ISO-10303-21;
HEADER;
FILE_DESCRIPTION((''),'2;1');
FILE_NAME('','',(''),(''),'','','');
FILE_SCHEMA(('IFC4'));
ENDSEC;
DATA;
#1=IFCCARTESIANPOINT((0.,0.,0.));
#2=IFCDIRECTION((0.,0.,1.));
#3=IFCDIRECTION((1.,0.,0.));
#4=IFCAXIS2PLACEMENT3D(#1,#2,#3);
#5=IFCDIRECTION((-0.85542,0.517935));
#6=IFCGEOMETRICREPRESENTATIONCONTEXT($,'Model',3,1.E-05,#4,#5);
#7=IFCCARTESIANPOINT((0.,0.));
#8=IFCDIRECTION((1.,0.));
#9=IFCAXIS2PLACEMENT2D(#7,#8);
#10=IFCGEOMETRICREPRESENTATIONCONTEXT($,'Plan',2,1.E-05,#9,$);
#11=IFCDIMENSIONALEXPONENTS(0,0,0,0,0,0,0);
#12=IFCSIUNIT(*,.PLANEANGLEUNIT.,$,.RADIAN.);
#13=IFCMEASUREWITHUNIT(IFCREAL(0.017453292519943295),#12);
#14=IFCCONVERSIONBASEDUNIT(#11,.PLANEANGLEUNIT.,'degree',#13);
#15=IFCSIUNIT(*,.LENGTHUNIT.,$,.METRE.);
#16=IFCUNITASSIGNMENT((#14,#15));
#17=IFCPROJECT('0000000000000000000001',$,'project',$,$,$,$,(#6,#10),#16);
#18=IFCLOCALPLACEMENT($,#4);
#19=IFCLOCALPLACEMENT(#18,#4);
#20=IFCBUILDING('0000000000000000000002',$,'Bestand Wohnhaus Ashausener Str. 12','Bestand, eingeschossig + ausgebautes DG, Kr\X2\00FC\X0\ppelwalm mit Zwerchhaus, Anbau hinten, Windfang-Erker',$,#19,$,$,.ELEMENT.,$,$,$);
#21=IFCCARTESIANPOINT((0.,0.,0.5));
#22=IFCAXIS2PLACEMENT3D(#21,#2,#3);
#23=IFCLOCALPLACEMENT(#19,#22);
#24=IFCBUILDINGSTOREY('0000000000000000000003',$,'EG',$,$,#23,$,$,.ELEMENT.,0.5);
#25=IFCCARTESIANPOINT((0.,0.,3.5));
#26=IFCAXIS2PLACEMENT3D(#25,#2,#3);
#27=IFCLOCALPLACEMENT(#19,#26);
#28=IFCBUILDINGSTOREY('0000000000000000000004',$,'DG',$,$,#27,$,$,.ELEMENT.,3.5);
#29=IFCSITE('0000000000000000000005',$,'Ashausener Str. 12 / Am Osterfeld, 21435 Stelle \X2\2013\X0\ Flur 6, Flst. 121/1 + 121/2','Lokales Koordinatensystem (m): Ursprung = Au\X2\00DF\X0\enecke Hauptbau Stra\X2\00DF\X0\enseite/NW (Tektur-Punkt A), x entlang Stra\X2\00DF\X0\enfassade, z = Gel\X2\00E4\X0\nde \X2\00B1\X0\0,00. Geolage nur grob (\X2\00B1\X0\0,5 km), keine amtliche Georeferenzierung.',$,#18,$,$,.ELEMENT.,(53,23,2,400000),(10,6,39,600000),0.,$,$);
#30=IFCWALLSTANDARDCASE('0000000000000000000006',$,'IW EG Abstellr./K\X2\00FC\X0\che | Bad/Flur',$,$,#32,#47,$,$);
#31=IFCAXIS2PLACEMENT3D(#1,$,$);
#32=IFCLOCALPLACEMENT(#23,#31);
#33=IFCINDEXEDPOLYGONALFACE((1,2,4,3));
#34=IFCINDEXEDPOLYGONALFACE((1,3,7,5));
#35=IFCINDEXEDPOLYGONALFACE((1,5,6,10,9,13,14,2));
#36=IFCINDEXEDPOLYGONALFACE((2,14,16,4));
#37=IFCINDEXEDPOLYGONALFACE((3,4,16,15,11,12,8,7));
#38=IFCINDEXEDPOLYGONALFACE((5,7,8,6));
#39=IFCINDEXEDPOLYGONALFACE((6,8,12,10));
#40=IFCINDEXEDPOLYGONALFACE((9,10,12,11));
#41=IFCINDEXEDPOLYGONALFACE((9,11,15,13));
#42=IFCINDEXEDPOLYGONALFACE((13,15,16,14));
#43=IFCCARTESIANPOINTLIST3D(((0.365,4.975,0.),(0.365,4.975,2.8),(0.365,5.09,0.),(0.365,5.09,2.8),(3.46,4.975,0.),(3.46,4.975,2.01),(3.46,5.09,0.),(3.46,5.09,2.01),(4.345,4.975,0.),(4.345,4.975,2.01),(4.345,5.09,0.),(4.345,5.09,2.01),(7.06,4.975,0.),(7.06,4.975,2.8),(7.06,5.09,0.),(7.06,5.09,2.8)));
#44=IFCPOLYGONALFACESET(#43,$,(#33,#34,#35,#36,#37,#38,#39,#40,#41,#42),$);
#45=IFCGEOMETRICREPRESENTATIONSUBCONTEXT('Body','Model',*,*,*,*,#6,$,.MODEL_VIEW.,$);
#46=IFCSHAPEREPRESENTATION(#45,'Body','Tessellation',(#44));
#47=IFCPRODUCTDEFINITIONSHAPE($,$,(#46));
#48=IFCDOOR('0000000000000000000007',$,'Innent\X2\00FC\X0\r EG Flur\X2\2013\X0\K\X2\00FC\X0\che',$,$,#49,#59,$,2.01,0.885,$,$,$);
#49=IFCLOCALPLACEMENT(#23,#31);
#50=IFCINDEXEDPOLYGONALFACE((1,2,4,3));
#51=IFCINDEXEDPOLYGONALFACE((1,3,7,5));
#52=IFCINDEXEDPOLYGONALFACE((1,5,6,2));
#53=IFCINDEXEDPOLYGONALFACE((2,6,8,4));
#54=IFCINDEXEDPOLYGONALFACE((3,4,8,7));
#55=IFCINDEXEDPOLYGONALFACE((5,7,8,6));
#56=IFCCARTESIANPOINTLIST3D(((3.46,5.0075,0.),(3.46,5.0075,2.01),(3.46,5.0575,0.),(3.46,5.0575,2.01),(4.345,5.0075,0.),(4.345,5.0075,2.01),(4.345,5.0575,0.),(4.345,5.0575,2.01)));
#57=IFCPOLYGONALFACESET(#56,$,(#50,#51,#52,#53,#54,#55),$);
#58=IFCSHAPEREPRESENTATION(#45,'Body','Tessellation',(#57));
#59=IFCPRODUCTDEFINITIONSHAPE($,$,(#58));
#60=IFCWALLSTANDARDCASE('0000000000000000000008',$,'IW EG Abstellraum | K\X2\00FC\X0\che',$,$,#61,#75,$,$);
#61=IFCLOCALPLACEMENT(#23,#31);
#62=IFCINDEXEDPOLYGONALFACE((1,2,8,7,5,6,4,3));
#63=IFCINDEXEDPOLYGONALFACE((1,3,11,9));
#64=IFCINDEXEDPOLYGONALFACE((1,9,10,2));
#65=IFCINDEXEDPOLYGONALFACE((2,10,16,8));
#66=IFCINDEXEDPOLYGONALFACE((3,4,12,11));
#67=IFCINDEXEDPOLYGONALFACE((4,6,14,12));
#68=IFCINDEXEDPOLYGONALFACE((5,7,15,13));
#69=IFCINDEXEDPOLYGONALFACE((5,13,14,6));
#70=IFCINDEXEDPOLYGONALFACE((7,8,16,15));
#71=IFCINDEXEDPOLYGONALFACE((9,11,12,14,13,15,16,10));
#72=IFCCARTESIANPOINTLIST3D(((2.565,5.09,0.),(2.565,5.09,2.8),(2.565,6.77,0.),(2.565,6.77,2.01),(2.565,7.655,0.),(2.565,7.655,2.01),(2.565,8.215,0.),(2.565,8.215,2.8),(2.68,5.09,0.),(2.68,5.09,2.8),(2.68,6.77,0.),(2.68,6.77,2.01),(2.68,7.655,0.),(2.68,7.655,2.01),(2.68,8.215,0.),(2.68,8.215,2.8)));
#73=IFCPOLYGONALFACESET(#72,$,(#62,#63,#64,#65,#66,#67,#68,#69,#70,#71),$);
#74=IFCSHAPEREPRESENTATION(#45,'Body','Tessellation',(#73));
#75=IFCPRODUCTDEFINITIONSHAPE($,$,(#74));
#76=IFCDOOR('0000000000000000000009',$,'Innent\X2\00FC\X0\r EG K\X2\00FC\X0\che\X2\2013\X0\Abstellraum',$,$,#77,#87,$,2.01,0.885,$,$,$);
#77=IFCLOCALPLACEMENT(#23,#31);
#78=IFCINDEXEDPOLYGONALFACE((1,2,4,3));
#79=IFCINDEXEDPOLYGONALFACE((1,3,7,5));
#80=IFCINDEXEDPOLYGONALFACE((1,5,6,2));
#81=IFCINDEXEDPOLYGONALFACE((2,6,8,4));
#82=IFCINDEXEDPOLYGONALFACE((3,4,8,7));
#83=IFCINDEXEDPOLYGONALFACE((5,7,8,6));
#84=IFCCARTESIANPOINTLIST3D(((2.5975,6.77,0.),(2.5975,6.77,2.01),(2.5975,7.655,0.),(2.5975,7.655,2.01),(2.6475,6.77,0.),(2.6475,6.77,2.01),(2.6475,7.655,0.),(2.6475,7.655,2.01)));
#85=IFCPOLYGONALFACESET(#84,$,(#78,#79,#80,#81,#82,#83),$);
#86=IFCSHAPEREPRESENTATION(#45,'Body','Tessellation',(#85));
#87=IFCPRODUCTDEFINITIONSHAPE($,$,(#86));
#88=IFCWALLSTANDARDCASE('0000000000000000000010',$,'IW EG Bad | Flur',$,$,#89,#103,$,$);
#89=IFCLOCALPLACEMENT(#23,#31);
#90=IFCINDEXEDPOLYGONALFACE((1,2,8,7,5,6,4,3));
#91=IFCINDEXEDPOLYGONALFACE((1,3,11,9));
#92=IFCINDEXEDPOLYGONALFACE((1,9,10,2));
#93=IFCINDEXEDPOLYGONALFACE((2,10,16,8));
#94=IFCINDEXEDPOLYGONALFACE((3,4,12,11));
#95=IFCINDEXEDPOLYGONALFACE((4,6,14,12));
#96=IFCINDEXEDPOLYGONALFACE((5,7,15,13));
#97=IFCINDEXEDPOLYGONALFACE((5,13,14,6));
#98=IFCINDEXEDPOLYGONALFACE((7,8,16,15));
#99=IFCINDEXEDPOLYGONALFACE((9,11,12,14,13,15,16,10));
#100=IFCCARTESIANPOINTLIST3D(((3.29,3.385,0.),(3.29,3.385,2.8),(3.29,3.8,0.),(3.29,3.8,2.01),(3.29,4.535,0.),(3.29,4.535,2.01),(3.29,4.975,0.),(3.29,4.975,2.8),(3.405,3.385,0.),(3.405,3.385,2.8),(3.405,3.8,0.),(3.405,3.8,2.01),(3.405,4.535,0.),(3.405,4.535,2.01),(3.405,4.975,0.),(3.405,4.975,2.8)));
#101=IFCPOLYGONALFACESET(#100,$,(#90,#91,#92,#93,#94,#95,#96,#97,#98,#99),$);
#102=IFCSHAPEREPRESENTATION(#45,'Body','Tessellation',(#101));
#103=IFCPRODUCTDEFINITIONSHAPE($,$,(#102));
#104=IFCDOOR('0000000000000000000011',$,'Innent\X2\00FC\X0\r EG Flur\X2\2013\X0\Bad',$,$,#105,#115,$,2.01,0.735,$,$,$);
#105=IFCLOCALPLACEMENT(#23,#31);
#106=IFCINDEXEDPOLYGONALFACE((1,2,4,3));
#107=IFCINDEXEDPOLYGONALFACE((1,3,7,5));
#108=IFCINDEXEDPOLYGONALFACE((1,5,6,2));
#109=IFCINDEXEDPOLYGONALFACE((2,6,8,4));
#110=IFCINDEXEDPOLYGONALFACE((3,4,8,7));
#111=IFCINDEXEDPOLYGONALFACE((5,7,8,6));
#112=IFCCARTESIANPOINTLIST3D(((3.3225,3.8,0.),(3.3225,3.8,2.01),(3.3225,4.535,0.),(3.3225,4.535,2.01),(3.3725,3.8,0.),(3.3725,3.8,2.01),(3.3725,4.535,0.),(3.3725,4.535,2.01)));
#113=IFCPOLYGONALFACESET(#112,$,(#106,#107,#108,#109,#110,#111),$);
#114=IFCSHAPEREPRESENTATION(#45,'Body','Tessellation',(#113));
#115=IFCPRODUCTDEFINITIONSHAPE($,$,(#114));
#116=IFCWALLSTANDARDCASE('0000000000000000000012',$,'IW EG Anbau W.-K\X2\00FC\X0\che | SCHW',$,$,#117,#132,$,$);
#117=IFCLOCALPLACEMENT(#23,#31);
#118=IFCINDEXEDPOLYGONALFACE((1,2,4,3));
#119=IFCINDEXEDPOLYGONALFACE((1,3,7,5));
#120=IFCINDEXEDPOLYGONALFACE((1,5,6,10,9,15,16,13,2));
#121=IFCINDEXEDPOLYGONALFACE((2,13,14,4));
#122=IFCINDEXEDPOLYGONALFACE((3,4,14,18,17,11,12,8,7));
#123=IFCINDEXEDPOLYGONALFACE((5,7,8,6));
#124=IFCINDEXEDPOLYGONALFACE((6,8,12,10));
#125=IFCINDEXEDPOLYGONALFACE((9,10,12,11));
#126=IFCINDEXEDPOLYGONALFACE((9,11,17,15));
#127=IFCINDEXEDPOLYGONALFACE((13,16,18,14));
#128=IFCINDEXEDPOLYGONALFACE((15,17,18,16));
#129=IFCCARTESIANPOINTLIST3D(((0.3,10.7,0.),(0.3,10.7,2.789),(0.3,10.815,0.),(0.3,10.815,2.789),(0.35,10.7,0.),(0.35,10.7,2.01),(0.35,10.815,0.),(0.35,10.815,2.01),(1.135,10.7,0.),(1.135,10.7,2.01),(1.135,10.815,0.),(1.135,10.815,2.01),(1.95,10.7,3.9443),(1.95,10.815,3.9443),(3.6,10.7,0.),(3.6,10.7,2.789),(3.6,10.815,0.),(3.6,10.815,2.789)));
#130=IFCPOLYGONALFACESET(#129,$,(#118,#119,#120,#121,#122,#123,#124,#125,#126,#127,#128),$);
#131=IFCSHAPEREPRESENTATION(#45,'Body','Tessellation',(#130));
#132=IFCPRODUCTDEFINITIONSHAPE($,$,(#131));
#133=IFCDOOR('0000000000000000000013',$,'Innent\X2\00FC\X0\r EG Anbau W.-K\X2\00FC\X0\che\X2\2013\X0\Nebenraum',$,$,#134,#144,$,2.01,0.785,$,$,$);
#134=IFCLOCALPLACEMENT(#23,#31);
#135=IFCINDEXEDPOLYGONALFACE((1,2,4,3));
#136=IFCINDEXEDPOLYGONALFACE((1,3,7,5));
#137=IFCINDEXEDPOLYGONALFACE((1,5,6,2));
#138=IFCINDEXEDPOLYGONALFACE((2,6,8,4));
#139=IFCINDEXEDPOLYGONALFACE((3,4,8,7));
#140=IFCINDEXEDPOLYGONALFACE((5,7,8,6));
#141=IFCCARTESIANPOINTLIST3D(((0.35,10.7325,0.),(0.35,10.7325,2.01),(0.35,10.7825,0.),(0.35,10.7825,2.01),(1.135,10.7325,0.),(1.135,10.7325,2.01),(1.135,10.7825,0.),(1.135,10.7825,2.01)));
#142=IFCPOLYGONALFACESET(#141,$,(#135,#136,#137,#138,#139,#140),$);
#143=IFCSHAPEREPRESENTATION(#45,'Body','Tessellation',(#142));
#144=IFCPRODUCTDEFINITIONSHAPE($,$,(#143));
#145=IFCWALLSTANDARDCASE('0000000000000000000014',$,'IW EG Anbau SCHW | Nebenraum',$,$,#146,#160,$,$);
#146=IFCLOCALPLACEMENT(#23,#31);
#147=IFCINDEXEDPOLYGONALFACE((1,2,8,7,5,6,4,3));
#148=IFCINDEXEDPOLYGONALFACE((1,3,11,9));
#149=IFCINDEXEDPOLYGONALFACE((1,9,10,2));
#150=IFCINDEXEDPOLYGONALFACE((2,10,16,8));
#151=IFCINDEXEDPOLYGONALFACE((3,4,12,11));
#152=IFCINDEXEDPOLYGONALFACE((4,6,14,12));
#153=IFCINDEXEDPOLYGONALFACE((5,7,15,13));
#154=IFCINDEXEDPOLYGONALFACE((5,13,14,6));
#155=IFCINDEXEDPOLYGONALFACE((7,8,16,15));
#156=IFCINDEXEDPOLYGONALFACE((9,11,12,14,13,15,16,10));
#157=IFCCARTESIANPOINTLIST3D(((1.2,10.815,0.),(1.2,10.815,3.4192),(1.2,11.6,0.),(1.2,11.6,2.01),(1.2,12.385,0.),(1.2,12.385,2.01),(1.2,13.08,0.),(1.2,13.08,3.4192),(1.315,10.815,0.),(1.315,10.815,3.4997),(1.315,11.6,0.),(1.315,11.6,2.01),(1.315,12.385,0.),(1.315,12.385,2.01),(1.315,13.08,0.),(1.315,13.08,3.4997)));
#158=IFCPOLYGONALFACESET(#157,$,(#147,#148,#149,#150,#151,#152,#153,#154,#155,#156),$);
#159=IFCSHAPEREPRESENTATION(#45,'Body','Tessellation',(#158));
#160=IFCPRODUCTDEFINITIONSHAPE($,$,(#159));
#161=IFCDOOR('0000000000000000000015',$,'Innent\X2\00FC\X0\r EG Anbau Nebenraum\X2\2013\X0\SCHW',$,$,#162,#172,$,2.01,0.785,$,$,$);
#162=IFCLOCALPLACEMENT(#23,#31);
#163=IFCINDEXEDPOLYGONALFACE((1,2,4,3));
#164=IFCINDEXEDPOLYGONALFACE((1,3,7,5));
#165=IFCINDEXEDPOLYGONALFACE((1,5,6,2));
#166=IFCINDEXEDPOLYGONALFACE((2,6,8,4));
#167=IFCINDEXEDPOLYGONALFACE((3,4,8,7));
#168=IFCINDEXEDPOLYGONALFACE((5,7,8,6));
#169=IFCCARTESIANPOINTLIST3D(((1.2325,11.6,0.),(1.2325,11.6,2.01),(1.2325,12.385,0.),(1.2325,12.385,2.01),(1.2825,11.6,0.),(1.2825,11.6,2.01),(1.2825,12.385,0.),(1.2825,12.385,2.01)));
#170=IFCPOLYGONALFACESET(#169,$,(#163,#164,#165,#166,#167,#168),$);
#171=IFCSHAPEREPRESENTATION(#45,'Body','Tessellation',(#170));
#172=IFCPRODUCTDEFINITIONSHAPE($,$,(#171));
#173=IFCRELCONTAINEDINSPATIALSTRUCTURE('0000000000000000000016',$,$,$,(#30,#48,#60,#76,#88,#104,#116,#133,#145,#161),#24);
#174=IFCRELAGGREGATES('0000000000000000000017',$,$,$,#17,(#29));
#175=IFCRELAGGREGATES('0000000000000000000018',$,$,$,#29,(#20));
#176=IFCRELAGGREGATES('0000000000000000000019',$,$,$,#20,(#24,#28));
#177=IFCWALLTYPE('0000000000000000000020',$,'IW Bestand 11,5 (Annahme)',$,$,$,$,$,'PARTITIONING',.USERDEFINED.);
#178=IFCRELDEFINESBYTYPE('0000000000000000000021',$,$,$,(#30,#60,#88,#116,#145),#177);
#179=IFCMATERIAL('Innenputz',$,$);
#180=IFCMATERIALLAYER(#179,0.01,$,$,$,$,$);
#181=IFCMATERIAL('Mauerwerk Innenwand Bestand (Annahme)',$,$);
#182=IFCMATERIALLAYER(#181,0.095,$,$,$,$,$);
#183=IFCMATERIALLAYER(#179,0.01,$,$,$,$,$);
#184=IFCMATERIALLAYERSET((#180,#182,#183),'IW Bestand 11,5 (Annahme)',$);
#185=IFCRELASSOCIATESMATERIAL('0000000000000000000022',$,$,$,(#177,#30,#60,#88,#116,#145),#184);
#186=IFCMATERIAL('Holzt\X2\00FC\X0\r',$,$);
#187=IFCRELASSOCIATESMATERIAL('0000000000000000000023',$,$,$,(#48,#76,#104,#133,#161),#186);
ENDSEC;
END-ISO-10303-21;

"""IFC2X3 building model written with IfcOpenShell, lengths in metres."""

from ifc_helpers import new_model, entity, si_unit, converted_unit, direction, frame, origin_with_axes, origin_2d_with_axis, place, context, subcontext, project, spatial, polyline, outline, extrude, clip, halfspace, material, layer, layer_set, layer_usage, type_object, element, fill, save


model = new_model("IFC2X3")

# Units and contexts
model_context = context("Model", 3, precision=1e-05, world=origin_with_axes(), true_north=direction((-0.85542, 0.517935)))
plan_context = context("Plan", 2, precision=1e-05, world=origin_2d_with_axis())
body_context = subcontext(model_context, "Body", "Model", "MODEL_VIEW")
ifc_project = project(units=[converted_unit("PLANEANGLEUNIT", "degree", entity("IfcReal", 0.017453292519943295), si_unit("PLANEANGLEUNIT", "RADIAN"), dimensions=[0, 0, 0, 0, 0, 0, 0]), si_unit("LENGTHUNIT", "METRE")], contexts=[model_context, plan_context])

# Site, building, storey
site_placement = place(None, origin_with_axes())
site = spatial("IfcSite", under=ifc_project, at=site_placement, Name="Ashausener Str. 12 / Am Osterfeld, 21435 Stelle – Flur 6, Flst. 121/1 + 121/2", Description="Lokales Koordinatensystem (m): Ursprung = Außenecke Hauptbau Straßenseite/NW (Tektur-Punkt A), x entlang Straßenfassade, z = Gelände ±0,00. Geolage nur grob (±0,5 km), keine amtliche Georeferenzierung.", CompositionType="ELEMENT", RefLatitude=(53, 23, 2, 400000), RefLongitude=(10, 6, 39, 600000), RefElevation=0.0)
building_placement = place(site_placement, origin_with_axes())
building = spatial("IfcBuilding", under=site, at=building_placement, Name="Bestand Wohnhaus Ashausener Str. 12", Description="Bestand, eingeschossig + ausgebautes DG, Krüppelwalm mit Zwerchhaus, Anbau hinten, Windfang-Erker", CompositionType="ELEMENT")
storey_1_placement = place(building_placement, frame((0.0, 0.0, 0.5), z_axis=(0.0, 0.0, 1.0), x_axis=(1.0, 0.0, 0.0)))
storey_1 = spatial("IfcBuildingStorey", under=building, at=storey_1_placement, Name="EG", CompositionType="ELEMENT", Elevation=0.5)

# Shared definitions
storey_2_placement = place(building_placement, frame((0.0, 0.0, 3.5), z_axis=(0.0, 0.0, 1.0), x_axis=(1.0, 0.0, 0.0)))
storey_2 = spatial("IfcBuildingStorey", under=building, at=storey_2_placement, Name="DG", CompositionType="ELEMENT", Elevation=3.5)

# Walls, openings, doors
ifc_material_1 = material(Name="Innenputz")
ifc_layer_1 = layer(ifc_material_1, 0.01)
ifc_material_2 = material(Name="Mauerwerk Innenwand Bestand (Annahme)")
ifc_layer_2 = layer(ifc_material_2, 0.095)
ifc_layer_3 = layer(ifc_material_1, 0.01)
ifc_layer_set_1 = layer_set([ifc_layer_1, ifc_layer_2, ifc_layer_3], Name="IW Bestand 11,5 (Annahme)")
ifc_layer_usage_1 = layer_usage(ifc_layer_set_1, "AXIS2", "POSITIVE", 0.0)
wall_type_1 = type_object("IfcWallType", Name="IW Bestand 11,5 (Annahme)", ElementType="PARTITIONING", PredefinedType="USERDEFINED", material=ifc_layer_set_1)
wall_1_placement = place(storey_1_placement, frame((0.365, 4.975, 0.0), z_axis=(0.0, 0.0, 1.0), x_axis=(1.0, 0.0, 0.0)))
wall_1 = element("IfcWallStandardCase", 1, at=wall_1_placement, inside=storey_1, type_object=wall_type_1, material=ifc_layer_usage_1, Name="IW EG Abstellr./Küche | Bad/Flur", context=body_context, shape_type="SweptSolid", body=[
    extrude(outline(polyline([(0.0, 0.0), (0.0, 0.115), (6.695, 0.115), (6.695, 0.0), (0.0, 0.0)])), origin_with_axes(), (0.0, 0.0, 1.0), 2.8),
])
opening_1_placement = place(wall_1_placement, frame((3.095, -0.1, 0.0), z_axis=(0.0, 0.0, 1.0), x_axis=(1.0, 0.0, 0.0)))
opening_1 = element("IfcOpeningElement", 2, at=opening_1_placement, cuts=wall_1, context=body_context, shape_type="SweptSolid", body=[
    extrude(outline(polyline([(0.0, 0.0), (0.0, 0.315), (0.885, 0.315), (0.885, 0.0), (0.0, 0.0)])), origin_with_axes(), (0.0, 0.0, 1.0), 2.01),
])
ifc_material_3 = material(Name="Holztür")
door_1_placement = place(storey_1_placement, frame((3.46, 5.0075, 0.0), z_axis=(0.0, 0.0, 1.0), x_axis=(1.0, 0.0, 0.0)))
door_1 = element("IfcDoor", 3, at=door_1_placement, inside=storey_1, material=ifc_material_3, Name="Innentür EG Flur–Küche", OverallHeight=2.01, OverallWidth=0.885, context=body_context, shape_type="SweptSolid", body=[
    extrude(outline(polyline([(0.0, 0.0), (0.0, 0.05), (0.885, 0.05), (0.885, 0.0), (0.0, 0.0)])), origin_with_axes(), (0.0, 0.0, 1.0), 2.01),
])
fill(opening_1, door_1)
ifc_layer_usage_2 = layer_usage(ifc_layer_set_1, "AXIS2", "POSITIVE", 0.0)
wall_2_placement = place(storey_1_placement, frame((2.565, 8.215, 0.0), z_axis=(0.0, 0.0, 1.0), x_axis=(0.0, -1.0, 0.0)))
wall_2 = element("IfcWallStandardCase", 4, at=wall_2_placement, inside=storey_1, type_object=wall_type_1, material=ifc_layer_usage_2, Name="IW EG Abstellraum | Küche", context=body_context, shape_type="SweptSolid", body=[
    extrude(outline(polyline([(0.0, 0.0), (0.0, 0.115), (3.125, 0.115), (3.125, 0.0), (0.0, 0.0)])), origin_with_axes(), (0.0, 0.0, 1.0), 2.8),
])
opening_2_placement = place(wall_2_placement, frame((0.56, -0.1, 0.0), z_axis=(0.0, 0.0, 1.0), x_axis=(1.0, 0.0, 0.0)))
opening_2 = element("IfcOpeningElement", 5, at=opening_2_placement, cuts=wall_2, context=body_context, shape_type="SweptSolid", body=[
    extrude(outline(polyline([(0.0, 0.0), (0.0, 0.315), (0.885, 0.315), (0.885, 0.0), (0.0, 0.0)])), origin_with_axes(), (0.0, 0.0, 1.0), 2.01),
])
door_2_placement = place(storey_1_placement, frame((2.5975, 7.655, 0.0), z_axis=(0.0, 0.0, 1.0), x_axis=(0.0, -1.0, 0.0)))
door_2 = element("IfcDoor", 6, at=door_2_placement, inside=storey_1, material=ifc_material_3, Name="Innentür EG Küche–Abstellraum", OverallHeight=2.01, OverallWidth=0.885, context=body_context, shape_type="SweptSolid", body=[
    extrude(outline(polyline([(0.0, 0.0), (0.0, 0.05), (0.885, 0.05), (0.885, 0.0), (0.0, 0.0)])), origin_with_axes(), (0.0, 0.0, 1.0), 2.01),
])
fill(opening_2, door_2)
ifc_layer_usage_3 = layer_usage(ifc_layer_set_1, "AXIS2", "POSITIVE", 0.0)
wall_3_placement = place(storey_1_placement, frame((3.29, 4.975, 0.0), z_axis=(0.0, 0.0, 1.0), x_axis=(0.0, -1.0, 0.0)))
wall_3 = element("IfcWallStandardCase", 7, at=wall_3_placement, inside=storey_1, type_object=wall_type_1, material=ifc_layer_usage_3, Name="IW EG Bad | Flur", context=body_context, shape_type="SweptSolid", body=[
    extrude(outline(polyline([(0.0, 0.0), (0.0, 0.115), (1.59, 0.115), (1.59, 0.0), (0.0, 0.0)])), origin_with_axes(), (0.0, 0.0, 1.0), 2.8),
])
opening_3_placement = place(wall_3_placement, frame((0.44, -0.1, 0.0), z_axis=(0.0, 0.0, 1.0), x_axis=(1.0, 0.0, 0.0)))
opening_3 = element("IfcOpeningElement", 8, at=opening_3_placement, cuts=wall_3, context=body_context, shape_type="SweptSolid", body=[
    extrude(outline(polyline([(0.0, 0.0), (0.0, 0.315), (0.735, 0.315), (0.735, 0.0), (0.0, 0.0)])), origin_with_axes(), (0.0, 0.0, 1.0), 2.01),
])
door_3_placement = place(storey_1_placement, frame((3.3225, 4.535, 0.0), z_axis=(0.0, 0.0, 1.0), x_axis=(0.0, -1.0, 0.0)))
door_3 = element("IfcDoor", 9, at=door_3_placement, inside=storey_1, material=ifc_material_3, Name="Innentür EG Flur–Bad", OverallHeight=2.01, OverallWidth=0.735, context=body_context, shape_type="SweptSolid", body=[
    extrude(outline(polyline([(0.0, 0.0), (0.0, 0.05), (0.735, 0.05), (0.735, 0.0), (0.0, 0.0)])), origin_with_axes(), (0.0, 0.0, 1.0), 2.01),
])
fill(opening_3, door_3)
ifc_layer_usage_4 = layer_usage(ifc_layer_set_1, "AXIS2", "POSITIVE", 0.0)
wall_4_placement = place(storey_1_placement, frame((0.3, 10.7, 0.0), z_axis=(0.0, 0.0, 1.0), x_axis=(1.0, 0.0, 0.0)))
wall_4 = element("IfcWallStandardCase", 10, at=wall_4_placement, inside=storey_1, type_object=wall_type_1, material=ifc_layer_usage_4, Name="IW EG Anbau W.-Küche | SCHW", context=body_context, shape_type="Clipping", body=[
    clip(clip(extrude(outline(polyline([(0.0, 0.0), (0.0, 0.115), (3.3, 0.115), (3.3, 0.0), (0.0, 0.0)])), origin_with_axes(), (0.0, 0.0, 1.0), 8.0), halfspace(frame((3.8753, -10.7, 2.3862), z_axis=(0.57358, 0.0, 0.81915), x_axis=(0.0, -1.0, 0.0)), False)), halfspace(frame((-0.5753, -10.7, 2.3862), z_axis=(-0.57358, 0.0, 0.81915), x_axis=(0.0, 1.0, 0.0)), False)),
])
opening_4_placement = place(wall_4_placement, frame((0.05, -0.1, 0.0), z_axis=(0.0, 0.0, 1.0), x_axis=(1.0, 0.0, 0.0)))
opening_4 = element("IfcOpeningElement", 11, at=opening_4_placement, cuts=wall_4, context=body_context, shape_type="SweptSolid", body=[
    extrude(outline(polyline([(0.0, 0.0), (0.0, 0.315), (0.785, 0.315), (0.785, 0.0), (0.0, 0.0)])), origin_with_axes(), (0.0, 0.0, 1.0), 2.01),
])
door_4_placement = place(storey_1_placement, frame((0.35, 10.7325, 0.0), z_axis=(0.0, 0.0, 1.0), x_axis=(1.0, 0.0, 0.0)))
door_4 = element("IfcDoor", 12, at=door_4_placement, inside=storey_1, material=ifc_material_3, Name="Innentür EG Anbau W.-Küche–Nebenraum", OverallHeight=2.01, OverallWidth=0.785, context=body_context, shape_type="SweptSolid", body=[
    extrude(outline(polyline([(0.0, 0.0), (0.0, 0.05), (0.785, 0.05), (0.785, 0.0), (0.0, 0.0)])), origin_with_axes(), (0.0, 0.0, 1.0), 2.01),
])
fill(opening_4, door_4)
ifc_layer_usage_5 = layer_usage(ifc_layer_set_1, "AXIS2", "POSITIVE", 0.0)
wall_5_placement = place(storey_1_placement, frame((1.2, 13.08, 0.0), z_axis=(0.0, 0.0, 1.0), x_axis=(0.0, -1.0, 0.0)))
wall_5 = element("IfcWallStandardCase", 13, at=wall_5_placement, inside=storey_1, type_object=wall_type_1, material=ifc_layer_usage_5, Name="IW EG Anbau SCHW | Nebenraum", context=body_context, shape_type="Clipping", body=[
    clip(clip(extrude(outline(polyline([(0.0, 0.0), (0.0, 0.115), (2.265, 0.115), (2.265, 0.0), (0.0, 0.0)])), origin_with_axes(), (0.0, 0.0, 1.0), 8.0), halfspace(frame((13.08, 2.9753, 2.3862), z_axis=(0.0, 0.57358, 0.81915), x_axis=(1.0, 0.0, 0.0)), False)), halfspace(frame((13.08, -1.4753, 2.3862), z_axis=(0.0, -0.57358, 0.81915), x_axis=(-1.0, 0.0, 0.0)), False)),
])
opening_5_placement = place(wall_5_placement, frame((0.695, -0.1, 0.0), z_axis=(0.0, 0.0, 1.0), x_axis=(1.0, 0.0, 0.0)))
opening_5 = element("IfcOpeningElement", 14, at=opening_5_placement, cuts=wall_5, context=body_context, shape_type="SweptSolid", body=[
    extrude(outline(polyline([(0.0, 0.0), (0.0, 0.315), (0.785, 0.315), (0.785, 0.0), (0.0, 0.0)])), origin_with_axes(), (0.0, 0.0, 1.0), 2.01),
])
door_5_placement = place(storey_1_placement, frame((1.2325, 12.385, 0.0), z_axis=(0.0, 0.0, 1.0), x_axis=(0.0, -1.0, 0.0)))
door_5 = element("IfcDoor", 15, at=door_5_placement, inside=storey_1, material=ifc_material_3, Name="Innentür EG Anbau Nebenraum–SCHW", OverallHeight=2.01, OverallWidth=0.785, context=body_context, shape_type="SweptSolid", body=[
    extrude(outline(polyline([(0.0, 0.0), (0.0, 0.05), (0.785, 0.05), (0.785, 0.0), (0.0, 0.0)])), origin_with_axes(), (0.0, 0.0, 1.0), 2.01),
])
fill(opening_5, door_5)

save(model, "model.ifc")
